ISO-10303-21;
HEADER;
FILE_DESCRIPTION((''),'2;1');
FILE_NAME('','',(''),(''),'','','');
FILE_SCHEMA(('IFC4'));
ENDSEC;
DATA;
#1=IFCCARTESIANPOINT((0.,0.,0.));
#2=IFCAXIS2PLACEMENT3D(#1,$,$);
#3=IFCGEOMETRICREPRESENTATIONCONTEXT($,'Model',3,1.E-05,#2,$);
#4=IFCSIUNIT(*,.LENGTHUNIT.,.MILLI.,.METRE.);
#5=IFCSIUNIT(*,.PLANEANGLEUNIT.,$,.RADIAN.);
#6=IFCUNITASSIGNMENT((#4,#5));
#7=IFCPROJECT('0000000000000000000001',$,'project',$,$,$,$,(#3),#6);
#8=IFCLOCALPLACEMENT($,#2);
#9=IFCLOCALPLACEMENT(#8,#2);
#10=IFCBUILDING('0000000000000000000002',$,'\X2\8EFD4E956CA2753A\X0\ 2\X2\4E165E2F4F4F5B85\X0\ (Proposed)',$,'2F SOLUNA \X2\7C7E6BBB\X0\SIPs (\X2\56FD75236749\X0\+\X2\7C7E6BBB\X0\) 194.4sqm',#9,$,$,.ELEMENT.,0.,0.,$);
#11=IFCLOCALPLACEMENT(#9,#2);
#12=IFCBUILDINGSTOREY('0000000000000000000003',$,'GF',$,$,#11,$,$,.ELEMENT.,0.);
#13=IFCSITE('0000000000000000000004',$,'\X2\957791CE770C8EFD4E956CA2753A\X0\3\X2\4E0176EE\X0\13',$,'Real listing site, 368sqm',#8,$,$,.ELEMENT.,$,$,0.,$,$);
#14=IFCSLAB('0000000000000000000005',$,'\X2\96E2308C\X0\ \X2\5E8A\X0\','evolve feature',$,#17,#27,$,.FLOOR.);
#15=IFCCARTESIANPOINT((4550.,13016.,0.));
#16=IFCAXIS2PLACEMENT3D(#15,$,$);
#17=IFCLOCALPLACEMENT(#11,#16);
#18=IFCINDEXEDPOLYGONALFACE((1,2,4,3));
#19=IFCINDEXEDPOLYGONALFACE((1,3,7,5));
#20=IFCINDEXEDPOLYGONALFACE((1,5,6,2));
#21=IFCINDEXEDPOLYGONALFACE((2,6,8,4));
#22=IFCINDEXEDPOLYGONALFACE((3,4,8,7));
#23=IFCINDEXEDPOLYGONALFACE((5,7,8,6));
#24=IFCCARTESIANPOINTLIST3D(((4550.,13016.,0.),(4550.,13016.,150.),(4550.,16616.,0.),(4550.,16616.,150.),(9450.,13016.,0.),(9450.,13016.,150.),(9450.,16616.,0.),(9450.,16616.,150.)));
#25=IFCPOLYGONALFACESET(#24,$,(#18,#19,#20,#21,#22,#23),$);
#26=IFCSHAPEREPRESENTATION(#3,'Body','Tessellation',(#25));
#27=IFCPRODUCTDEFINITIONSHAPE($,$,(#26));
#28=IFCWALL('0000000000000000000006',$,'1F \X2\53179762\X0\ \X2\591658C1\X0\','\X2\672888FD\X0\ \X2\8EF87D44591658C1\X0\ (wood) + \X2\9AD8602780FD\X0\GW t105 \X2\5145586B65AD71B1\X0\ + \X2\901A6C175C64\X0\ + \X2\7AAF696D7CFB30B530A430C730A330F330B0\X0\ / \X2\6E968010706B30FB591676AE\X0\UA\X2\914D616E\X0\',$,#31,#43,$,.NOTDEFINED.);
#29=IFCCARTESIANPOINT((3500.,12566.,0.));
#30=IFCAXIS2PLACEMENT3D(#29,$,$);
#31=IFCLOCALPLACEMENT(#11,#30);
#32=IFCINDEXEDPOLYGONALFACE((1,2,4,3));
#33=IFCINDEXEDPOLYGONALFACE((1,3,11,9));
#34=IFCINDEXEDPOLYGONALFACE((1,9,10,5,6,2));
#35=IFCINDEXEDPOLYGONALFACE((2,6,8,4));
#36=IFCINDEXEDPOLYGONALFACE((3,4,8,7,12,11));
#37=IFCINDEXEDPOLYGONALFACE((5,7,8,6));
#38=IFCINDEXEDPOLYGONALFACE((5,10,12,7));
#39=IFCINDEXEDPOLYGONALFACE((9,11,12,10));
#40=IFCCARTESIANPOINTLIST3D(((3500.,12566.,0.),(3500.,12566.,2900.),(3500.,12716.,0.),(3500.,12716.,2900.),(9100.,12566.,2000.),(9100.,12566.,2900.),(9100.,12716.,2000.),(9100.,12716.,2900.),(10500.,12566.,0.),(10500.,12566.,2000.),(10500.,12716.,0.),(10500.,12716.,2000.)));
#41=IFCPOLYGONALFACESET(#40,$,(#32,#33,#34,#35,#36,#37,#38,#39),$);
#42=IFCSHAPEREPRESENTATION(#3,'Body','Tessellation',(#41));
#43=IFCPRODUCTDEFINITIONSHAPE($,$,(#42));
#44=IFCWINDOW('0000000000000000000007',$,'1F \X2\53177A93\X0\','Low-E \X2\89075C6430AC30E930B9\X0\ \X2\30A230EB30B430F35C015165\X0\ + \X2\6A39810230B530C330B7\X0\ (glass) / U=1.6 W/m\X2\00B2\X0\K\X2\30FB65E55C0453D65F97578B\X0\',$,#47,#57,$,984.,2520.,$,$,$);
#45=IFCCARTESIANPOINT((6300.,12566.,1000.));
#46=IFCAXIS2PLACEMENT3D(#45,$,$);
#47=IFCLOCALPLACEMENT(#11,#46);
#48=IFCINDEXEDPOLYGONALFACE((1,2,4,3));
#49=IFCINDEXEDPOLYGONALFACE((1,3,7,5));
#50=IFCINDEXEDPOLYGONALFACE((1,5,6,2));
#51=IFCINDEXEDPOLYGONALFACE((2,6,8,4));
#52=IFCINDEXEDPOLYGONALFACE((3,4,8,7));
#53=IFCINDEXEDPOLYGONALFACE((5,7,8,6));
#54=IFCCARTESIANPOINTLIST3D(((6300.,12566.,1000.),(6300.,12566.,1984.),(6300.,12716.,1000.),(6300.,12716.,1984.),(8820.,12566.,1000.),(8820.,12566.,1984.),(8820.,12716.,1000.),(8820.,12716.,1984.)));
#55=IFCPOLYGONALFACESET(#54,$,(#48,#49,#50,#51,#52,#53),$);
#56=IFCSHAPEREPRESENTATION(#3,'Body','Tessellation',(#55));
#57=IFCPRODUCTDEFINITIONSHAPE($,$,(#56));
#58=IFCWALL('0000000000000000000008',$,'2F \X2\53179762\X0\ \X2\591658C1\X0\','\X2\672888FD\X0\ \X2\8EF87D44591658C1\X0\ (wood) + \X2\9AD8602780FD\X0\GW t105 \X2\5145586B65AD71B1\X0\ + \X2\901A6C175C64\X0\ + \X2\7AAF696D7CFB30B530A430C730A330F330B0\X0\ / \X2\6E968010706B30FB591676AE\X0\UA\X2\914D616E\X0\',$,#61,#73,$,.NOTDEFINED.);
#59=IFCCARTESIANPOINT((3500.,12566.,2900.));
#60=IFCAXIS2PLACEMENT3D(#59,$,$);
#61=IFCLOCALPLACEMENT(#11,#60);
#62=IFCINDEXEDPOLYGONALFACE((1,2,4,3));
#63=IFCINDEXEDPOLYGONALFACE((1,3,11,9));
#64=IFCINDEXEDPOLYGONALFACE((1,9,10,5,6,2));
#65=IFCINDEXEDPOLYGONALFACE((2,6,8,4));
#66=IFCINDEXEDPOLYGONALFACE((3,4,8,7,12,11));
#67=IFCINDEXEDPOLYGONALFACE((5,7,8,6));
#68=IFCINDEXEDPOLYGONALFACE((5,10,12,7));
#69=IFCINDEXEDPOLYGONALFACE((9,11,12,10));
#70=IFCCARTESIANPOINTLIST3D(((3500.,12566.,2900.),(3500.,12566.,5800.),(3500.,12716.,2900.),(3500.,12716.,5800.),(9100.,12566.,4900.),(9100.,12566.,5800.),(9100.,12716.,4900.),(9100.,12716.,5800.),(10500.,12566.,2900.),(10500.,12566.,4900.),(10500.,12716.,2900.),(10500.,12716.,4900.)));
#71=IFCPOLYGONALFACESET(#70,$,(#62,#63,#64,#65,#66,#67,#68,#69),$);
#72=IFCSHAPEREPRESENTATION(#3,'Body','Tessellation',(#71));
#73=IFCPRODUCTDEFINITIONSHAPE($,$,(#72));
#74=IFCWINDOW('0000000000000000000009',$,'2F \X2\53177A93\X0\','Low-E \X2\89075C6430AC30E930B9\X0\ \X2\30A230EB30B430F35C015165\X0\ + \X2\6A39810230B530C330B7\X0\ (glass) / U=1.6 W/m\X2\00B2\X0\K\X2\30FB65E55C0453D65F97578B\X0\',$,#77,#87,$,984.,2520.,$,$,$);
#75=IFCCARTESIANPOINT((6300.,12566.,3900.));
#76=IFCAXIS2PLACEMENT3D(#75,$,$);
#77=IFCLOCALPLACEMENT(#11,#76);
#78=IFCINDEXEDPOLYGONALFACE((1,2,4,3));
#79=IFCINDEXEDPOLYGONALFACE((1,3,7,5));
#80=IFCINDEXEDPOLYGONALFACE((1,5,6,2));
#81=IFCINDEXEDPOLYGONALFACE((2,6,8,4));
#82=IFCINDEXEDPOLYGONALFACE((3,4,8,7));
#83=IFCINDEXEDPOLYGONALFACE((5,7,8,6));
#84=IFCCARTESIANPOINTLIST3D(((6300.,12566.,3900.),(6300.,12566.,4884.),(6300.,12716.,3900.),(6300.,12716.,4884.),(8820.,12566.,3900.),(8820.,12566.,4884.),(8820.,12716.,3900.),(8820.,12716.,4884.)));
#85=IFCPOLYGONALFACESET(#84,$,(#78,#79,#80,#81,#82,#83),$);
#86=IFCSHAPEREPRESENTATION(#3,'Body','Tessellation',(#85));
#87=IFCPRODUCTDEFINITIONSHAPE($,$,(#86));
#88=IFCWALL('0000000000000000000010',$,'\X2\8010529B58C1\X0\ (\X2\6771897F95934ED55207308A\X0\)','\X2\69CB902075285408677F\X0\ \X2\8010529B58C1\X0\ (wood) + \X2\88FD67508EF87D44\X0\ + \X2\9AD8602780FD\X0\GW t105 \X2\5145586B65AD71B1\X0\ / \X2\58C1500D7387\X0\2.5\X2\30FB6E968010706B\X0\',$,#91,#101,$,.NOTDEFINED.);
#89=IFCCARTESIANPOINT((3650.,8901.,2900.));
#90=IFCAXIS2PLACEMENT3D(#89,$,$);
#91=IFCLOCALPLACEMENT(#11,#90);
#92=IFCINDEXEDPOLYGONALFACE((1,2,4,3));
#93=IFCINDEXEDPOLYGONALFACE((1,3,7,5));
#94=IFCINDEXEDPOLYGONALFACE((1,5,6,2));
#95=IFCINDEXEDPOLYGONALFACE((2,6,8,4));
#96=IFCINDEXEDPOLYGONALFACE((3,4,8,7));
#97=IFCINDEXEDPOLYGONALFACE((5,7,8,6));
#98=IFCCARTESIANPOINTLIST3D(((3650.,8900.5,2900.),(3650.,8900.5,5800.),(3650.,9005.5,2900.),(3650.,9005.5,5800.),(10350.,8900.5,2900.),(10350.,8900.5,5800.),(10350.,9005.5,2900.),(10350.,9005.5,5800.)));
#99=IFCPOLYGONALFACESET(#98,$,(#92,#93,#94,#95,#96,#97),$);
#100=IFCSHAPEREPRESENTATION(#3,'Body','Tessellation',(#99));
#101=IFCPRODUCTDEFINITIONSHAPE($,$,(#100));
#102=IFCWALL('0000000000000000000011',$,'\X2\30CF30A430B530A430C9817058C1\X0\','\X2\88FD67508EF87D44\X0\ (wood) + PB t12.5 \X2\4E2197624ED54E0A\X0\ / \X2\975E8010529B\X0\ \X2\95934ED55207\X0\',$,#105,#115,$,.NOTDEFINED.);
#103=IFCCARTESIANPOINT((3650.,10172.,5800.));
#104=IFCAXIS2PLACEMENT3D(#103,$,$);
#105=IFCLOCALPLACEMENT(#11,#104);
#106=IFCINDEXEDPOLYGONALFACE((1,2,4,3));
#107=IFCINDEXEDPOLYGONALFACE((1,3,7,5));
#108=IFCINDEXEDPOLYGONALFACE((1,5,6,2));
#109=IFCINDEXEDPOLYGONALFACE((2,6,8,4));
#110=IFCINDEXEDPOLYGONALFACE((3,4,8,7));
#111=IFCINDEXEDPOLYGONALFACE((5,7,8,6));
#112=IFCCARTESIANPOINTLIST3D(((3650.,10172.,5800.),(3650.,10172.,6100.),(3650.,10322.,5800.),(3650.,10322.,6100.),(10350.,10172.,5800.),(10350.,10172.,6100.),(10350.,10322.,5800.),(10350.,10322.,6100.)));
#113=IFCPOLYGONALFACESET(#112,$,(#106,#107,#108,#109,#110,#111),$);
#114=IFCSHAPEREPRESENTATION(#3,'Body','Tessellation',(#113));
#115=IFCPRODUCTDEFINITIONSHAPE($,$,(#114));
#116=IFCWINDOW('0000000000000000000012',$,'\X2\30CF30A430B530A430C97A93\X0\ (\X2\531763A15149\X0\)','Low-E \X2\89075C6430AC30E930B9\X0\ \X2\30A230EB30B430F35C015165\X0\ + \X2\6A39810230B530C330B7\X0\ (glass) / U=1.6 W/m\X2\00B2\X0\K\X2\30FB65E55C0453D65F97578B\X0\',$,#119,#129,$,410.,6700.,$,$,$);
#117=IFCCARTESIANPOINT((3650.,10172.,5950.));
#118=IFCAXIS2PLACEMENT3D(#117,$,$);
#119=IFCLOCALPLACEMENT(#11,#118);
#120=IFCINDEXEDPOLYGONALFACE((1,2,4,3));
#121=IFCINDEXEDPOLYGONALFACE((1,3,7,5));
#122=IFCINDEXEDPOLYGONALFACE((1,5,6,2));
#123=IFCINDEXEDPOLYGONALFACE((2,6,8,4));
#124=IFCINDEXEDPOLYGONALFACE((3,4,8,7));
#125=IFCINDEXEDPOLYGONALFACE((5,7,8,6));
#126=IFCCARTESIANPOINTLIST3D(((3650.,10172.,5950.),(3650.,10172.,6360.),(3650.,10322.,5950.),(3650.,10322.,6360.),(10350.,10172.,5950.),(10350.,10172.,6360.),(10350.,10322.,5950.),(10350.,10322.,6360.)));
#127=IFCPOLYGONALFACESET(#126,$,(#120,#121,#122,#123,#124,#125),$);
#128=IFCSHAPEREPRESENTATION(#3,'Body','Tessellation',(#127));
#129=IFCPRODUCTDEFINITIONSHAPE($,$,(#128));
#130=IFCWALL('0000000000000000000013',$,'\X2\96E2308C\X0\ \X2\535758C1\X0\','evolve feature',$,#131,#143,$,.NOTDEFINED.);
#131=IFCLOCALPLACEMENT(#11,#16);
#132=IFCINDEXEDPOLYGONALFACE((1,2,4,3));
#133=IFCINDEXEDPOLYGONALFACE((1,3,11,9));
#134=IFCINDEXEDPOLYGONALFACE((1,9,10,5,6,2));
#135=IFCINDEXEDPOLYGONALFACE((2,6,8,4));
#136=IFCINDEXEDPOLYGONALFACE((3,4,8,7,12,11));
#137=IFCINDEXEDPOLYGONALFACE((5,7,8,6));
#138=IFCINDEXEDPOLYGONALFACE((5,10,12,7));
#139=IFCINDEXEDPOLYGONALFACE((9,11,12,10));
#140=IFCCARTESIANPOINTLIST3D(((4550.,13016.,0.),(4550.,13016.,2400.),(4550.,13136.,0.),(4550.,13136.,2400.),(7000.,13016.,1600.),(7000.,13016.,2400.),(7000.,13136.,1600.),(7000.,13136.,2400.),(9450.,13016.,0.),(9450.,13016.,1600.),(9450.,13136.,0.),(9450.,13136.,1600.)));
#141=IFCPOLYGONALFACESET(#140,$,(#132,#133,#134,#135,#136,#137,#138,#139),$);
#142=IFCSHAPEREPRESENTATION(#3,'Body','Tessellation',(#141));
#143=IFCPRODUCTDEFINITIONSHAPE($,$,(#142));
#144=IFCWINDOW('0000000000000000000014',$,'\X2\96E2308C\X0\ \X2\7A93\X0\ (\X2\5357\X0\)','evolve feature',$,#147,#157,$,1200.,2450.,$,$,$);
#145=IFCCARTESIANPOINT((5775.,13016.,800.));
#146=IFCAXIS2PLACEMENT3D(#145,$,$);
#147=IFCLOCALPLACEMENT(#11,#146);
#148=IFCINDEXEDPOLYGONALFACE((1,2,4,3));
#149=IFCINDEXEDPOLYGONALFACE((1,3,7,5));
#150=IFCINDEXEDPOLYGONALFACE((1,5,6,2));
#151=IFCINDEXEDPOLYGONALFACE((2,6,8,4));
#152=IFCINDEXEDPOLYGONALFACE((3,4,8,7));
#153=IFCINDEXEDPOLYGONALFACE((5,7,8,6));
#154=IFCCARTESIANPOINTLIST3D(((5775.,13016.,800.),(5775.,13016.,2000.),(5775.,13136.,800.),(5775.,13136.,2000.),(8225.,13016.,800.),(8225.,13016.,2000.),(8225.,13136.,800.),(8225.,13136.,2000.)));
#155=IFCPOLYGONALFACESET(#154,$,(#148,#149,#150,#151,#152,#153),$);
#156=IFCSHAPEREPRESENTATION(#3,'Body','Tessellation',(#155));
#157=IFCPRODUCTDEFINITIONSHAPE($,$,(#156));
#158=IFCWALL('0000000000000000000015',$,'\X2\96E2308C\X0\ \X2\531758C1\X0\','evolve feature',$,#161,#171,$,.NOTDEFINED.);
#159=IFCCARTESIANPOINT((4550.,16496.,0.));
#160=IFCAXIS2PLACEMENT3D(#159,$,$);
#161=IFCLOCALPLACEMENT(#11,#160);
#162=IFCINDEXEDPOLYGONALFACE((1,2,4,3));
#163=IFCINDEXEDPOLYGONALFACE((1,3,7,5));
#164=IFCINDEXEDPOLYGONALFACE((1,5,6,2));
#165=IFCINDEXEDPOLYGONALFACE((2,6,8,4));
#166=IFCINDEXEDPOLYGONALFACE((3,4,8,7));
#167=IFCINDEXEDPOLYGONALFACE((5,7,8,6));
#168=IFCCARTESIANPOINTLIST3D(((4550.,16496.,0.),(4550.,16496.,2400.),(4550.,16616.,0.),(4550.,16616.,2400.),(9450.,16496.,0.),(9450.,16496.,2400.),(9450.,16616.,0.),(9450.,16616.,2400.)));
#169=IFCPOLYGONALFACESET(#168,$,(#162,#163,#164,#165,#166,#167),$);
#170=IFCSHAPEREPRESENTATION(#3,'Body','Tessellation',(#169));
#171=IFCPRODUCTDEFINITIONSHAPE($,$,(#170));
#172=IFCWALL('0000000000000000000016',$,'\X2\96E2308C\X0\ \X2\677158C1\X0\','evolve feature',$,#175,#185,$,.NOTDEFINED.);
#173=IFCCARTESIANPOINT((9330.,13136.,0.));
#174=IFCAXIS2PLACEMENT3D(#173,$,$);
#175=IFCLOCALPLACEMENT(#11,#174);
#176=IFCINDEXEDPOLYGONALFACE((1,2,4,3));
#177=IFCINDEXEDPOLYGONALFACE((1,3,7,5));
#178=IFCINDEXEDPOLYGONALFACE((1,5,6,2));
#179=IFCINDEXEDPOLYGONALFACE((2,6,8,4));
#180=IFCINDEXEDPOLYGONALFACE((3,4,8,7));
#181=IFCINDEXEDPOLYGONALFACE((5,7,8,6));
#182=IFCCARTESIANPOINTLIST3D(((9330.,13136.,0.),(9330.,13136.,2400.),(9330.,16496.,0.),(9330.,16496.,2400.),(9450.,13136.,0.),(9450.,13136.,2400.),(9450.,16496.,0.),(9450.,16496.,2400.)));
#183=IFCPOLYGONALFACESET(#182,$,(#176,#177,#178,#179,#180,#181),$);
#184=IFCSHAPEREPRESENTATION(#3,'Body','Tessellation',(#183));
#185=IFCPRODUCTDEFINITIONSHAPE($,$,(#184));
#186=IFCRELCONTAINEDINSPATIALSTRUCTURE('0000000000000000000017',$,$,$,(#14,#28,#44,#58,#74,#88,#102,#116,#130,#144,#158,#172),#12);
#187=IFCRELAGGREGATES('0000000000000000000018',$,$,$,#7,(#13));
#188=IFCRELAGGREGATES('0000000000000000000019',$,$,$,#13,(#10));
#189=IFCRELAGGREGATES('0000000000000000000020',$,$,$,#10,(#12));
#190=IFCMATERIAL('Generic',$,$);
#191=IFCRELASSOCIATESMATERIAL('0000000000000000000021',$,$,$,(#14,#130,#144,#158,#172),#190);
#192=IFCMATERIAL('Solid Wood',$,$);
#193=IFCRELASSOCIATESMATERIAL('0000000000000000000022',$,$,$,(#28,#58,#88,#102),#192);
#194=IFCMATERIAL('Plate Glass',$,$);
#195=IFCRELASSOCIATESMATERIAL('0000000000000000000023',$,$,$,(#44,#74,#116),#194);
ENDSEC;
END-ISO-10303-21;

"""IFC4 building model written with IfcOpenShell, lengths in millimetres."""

from ifc_helpers import new_model, si_unit, frame, frame_2d, origin, place, context, project, spatial, rectangle, extrude, material, element, fill, save


model = new_model("IFC4")

# Units and contexts
model_context = context("Model", 3, precision=1e-05, world=origin())
ifc_project = project(units=[si_unit("LENGTHUNIT", "METRE", prefix="MILLI"), si_unit("PLANEANGLEUNIT", "RADIAN")], contexts=[model_context])

# Site, building, storey
site_placement = place(None, origin())
site = spatial("IfcSite", under=ifc_project, at=site_placement, Name="長野県軽井沢町3丁目13", ObjectType="Real listing site, 368sqm", CompositionType="ELEMENT", RefElevation=0.0)
building_placement = place(site_placement, origin())
building = spatial("IfcBuilding", under=site, at=building_placement, Name="軽井沢町 2世帯住宅 (Proposed)", ObjectType="2F SOLUNA 籾殻SIPs (国産杉+籾殻) 194.4sqm", CompositionType="ELEMENT", ElevationOfRefHeight=0.0, ElevationOfTerrain=0.0)
storey_placement = place(building_placement, origin())
storey = spatial("IfcBuildingStorey", under=building, at=storey_placement, Name="GF", CompositionType="ELEMENT", Elevation=0.0)

# Slab
ifc_material_1 = material(Name="Generic")
slab_placement = place(storey_placement, frame((4550.0, 13016.0, 0.0)))
element("IfcSlab", 1, at=slab_placement, inside=storey, material=ifc_material_1, Name="離れ 床", Description="evolve feature", PredefinedType="FLOOR", context=model_context, shape_type="SweptSolid", body=[
    extrude(rectangle(XDim=4900.0, YDim=3600.0, at=frame_2d((2450.0, 1800.0))), frame((4550.0, 13016.0, 0.0)), (0.0, 0.0, 1.0), 150.0),
])

# Wall, opening, window
ifc_material_2 = material(Name="Solid Wood")
wall_1_placement = place(storey_placement, frame((3500.0, 12566.0, 0.0)))
wall_1 = element("IfcWall", 2, at=wall_1_placement, inside=storey, material=ifc_material_2, Name="1F 北面 外壁", Description="木製 軸組外壁 (wood) + 高性能GW t105 充填断熱 + 通気層 + 窯業系サイディング / 準耐火・外皮UA配慮", PredefinedType="NOTDEFINED", context=model_context, shape_type="SweptSolid", body=[
    extrude(rectangle(XDim=7000.0, YDim=150.0, at=frame_2d((3500.0, 75.0))), frame((3500.0, 12566.0, 0.0)), (0.0, 0.0, 1.0), 2900.0),
])
opening_1_placement = place(storey_placement, frame((6300.0, 12566.0, 1000.0)))
opening_1 = element("IfcOpeningElement", 3, at=opening_1_placement, cuts=wall_1, PredefinedType="NOTDEFINED", context=model_context, shape_type="SweptSolid", body=[
    extrude(rectangle(XDim=2520.0, YDim=150.0, at=frame_2d((1260.0, 75.0))), frame((6300.0, 12566.0, 1000.0)), (0.0, 0.0, 1.0), 984.0),
])
ifc_material_3 = material(Name="Plate Glass")
window_1_placement = place(storey_placement, frame((6300.0, 12566.0, 1000.0)))
window_1 = element("IfcWindow", 4, at=window_1_placement, inside=storey, material=ifc_material_3, Name="1F 北窓", Description="Low-E 複層ガラス アルゴン封入 + 樹脂サッシ (glass) / U=1.6 W/m²K・日射取得型", OverallHeight=984.0, OverallWidth=2520.0, context=model_context, shape_type="SweptSolid", body=[
    extrude(rectangle(XDim=2520.0, YDim=150.0, at=frame_2d((1260.0, 75.0))), frame((6300.0, 12566.0, 1000.0)), (0.0, 0.0, 1.0), 984.0),
])
fill(opening_1, window_1)

# Wall, opening, window
wall_2_placement = place(storey_placement, frame((3500.0, 12566.0, 2900.0)))
wall_2 = element("IfcWall", 5, at=wall_2_placement, inside=storey, material=ifc_material_2, Name="2F 北面 外壁", Description="木製 軸組外壁 (wood) + 高性能GW t105 充填断熱 + 通気層 + 窯業系サイディング / 準耐火・外皮UA配慮", PredefinedType="NOTDEFINED", context=model_context, shape_type="SweptSolid", body=[
    extrude(rectangle(XDim=7000.0, YDim=150.0, at=frame_2d((3500.0, 75.0))), frame((3500.0, 12566.0, 2900.0)), (0.0, 0.0, 1.0), 2900.0),
])
opening_2_placement = place(storey_placement, frame((6300.0, 12566.0, 3900.0)))
opening_2 = element("IfcOpeningElement", 6, at=opening_2_placement, cuts=wall_2, PredefinedType="NOTDEFINED", context=model_context, shape_type="SweptSolid", body=[
    extrude(rectangle(XDim=2520.0, YDim=150.0, at=frame_2d((1260.0, 75.0))), frame((6300.0, 12566.0, 3900.0)), (0.0, 0.0, 1.0), 984.0),
])
window_2_placement = place(storey_placement, frame((6300.0, 12566.0, 3900.0)))
window_2 = element("IfcWindow", 7, at=window_2_placement, inside=storey, material=ifc_material_3, Name="2F 北窓", Description="Low-E 複層ガラス アルゴン封入 + 樹脂サッシ (glass) / U=1.6 W/m²K・日射取得型", OverallHeight=984.0, OverallWidth=2520.0, context=model_context, shape_type="SweptSolid", body=[
    extrude(rectangle(XDim=2520.0, YDim=150.0, at=frame_2d((1260.0, 75.0))), frame((6300.0, 12566.0, 3900.0)), (0.0, 0.0, 1.0), 984.0),
])
fill(opening_2, window_2)

# Wall
wall_3_placement = place(storey_placement, frame((3650.0, 8901.0, 2900.0)))
element("IfcWall", 8, at=wall_3_placement, inside=storey, material=ifc_material_2, Name="耐力壁 (東西間仕切り)", Description="構造用合板 耐力壁 (wood) + 製材軸組 + 高性能GW t105 充填断熱 / 壁倍率2.5・準耐火", PredefinedType="NOTDEFINED", context=model_context, shape_type="SweptSolid", body=[
    extrude(rectangle(XDim=6700.0, YDim=105.0, at=frame_2d((3350.0, 52.0))), frame((3650.0, 8901.0, 2900.0)), (0.0, 0.0, 1.0), 2900.0),
])

# Walls, openings, windows
wall_4_placement = place(storey_placement, frame((3650.0, 10172.0, 5800.0)))
wall_4 = element("IfcWall", 9, at=wall_4_placement, inside=storey, material=ifc_material_2, Name="ハイサイド腰壁", Description="製材軸組 (wood) + PB t12.5 両面仕上 / 非耐力 間仕切", PredefinedType="NOTDEFINED", context=model_context, shape_type="SweptSolid", body=[
    extrude(rectangle(XDim=6700.0, YDim=150.0, at=frame_2d((3350.0, 75.0))), frame((3650.0, 10172.0, 5800.0)), (0.0, 0.0, 1.0), 700.0),
])
opening_3_placement = place(storey_placement, frame((3650.0, 10172.0, 5950.0)))
opening_3 = element("IfcOpeningElement", 10, at=opening_3_placement, cuts=wall_4, PredefinedType="NOTDEFINED", context=model_context, shape_type="SweptSolid", body=[
    extrude(rectangle(XDim=6700.0, YDim=150.0, at=frame_2d((3350.0, 75.0))), frame((3650.0, 10172.0, 5950.0)), (0.0, 0.0, 1.0), 410.0),
])
window_3_placement = place(storey_placement, frame((3650.0, 10172.0, 5950.0)))
window_3 = element("IfcWindow", 11, at=window_3_placement, inside=storey, material=ifc_material_3, Name="ハイサイド窓 (北採光)", Description="Low-E 複層ガラス アルゴン封入 + 樹脂サッシ (glass) / U=1.6 W/m²K・日射取得型", OverallHeight=410.0, OverallWidth=6700.0, context=model_context, shape_type="SweptSolid", body=[
    extrude(rectangle(XDim=6700.0, YDim=150.0, at=frame_2d((3350.0, 75.0))), frame((3650.0, 10172.0, 5950.0)), (0.0, 0.0, 1.0), 410.0),
])
fill(opening_3, window_3)
wall_5_placement = place(storey_placement, frame((4550.0, 13016.0, 0.0)))
wall_5 = element("IfcWall", 12, at=wall_5_placement, inside=storey, material=ifc_material_1, Name="離れ 南壁", Description="evolve feature", PredefinedType="NOTDEFINED", context=model_context, shape_type="SweptSolid", body=[
    extrude(rectangle(XDim=4900.0, YDim=120.0, at=frame_2d((2450.0, 60.0))), frame((4550.0, 13016.0, 0.0)), (0.0, 0.0, 1.0), 2400.0),
])
opening_4_placement = place(storey_placement, frame((5775.0, 13016.0, 800.0)))
opening_4 = element("IfcOpeningElement", 13, at=opening_4_placement, cuts=wall_5, PredefinedType="NOTDEFINED", context=model_context, shape_type="SweptSolid", body=[
    extrude(rectangle(XDim=2450.0, YDim=120.0, at=frame_2d((1225.0, 60.0))), frame((5775.0, 13016.0, 800.0)), (0.0, 0.0, 1.0), 1200.0),
])
window_4_placement = place(storey_placement, frame((5775.0, 13016.0, 800.0)))
window_4 = element("IfcWindow", 14, at=window_4_placement, inside=storey, material=ifc_material_1, Name="離れ 窓 (南)", Description="evolve feature", OverallHeight=1200.0, OverallWidth=2450.0, context=model_context, shape_type="SweptSolid", body=[
    extrude(rectangle(XDim=2450.0, YDim=120.0, at=frame_2d((1225.0, 60.0))), frame((5775.0, 13016.0, 800.0)), (0.0, 0.0, 1.0), 1200.0),
])
fill(opening_4, window_4)

# Walls
wall_6_placement = place(storey_placement, frame((4550.0, 16496.0, 0.0)))
element("IfcWall", 15, at=wall_6_placement, inside=storey, material=ifc_material_1, Name="離れ 北壁", Description="evolve feature", PredefinedType="NOTDEFINED", context=model_context, shape_type="SweptSolid", body=[
    extrude(rectangle(XDim=4900.0, YDim=120.0, at=frame_2d((2450.0, 60.0))), frame((4550.0, 16496.0, 0.0)), (0.0, 0.0, 1.0), 2400.0),
])
wall_7_placement = place(storey_placement, frame((9330.0, 13136.0, 0.0)))
element("IfcWall", 16, at=wall_7_placement, inside=storey, material=ifc_material_1, Name="離れ 東壁", Description="evolve feature", PredefinedType="NOTDEFINED", context=model_context, shape_type="SweptSolid", body=[
    extrude(rectangle(XDim=120.0, YDim=3360.0, at=frame_2d((60.0, 1680.0))), frame((9330.0, 13136.0, 0.0)), (0.0, 0.0, 1.0), 2400.0),
])

save(model, "model.ifc")
